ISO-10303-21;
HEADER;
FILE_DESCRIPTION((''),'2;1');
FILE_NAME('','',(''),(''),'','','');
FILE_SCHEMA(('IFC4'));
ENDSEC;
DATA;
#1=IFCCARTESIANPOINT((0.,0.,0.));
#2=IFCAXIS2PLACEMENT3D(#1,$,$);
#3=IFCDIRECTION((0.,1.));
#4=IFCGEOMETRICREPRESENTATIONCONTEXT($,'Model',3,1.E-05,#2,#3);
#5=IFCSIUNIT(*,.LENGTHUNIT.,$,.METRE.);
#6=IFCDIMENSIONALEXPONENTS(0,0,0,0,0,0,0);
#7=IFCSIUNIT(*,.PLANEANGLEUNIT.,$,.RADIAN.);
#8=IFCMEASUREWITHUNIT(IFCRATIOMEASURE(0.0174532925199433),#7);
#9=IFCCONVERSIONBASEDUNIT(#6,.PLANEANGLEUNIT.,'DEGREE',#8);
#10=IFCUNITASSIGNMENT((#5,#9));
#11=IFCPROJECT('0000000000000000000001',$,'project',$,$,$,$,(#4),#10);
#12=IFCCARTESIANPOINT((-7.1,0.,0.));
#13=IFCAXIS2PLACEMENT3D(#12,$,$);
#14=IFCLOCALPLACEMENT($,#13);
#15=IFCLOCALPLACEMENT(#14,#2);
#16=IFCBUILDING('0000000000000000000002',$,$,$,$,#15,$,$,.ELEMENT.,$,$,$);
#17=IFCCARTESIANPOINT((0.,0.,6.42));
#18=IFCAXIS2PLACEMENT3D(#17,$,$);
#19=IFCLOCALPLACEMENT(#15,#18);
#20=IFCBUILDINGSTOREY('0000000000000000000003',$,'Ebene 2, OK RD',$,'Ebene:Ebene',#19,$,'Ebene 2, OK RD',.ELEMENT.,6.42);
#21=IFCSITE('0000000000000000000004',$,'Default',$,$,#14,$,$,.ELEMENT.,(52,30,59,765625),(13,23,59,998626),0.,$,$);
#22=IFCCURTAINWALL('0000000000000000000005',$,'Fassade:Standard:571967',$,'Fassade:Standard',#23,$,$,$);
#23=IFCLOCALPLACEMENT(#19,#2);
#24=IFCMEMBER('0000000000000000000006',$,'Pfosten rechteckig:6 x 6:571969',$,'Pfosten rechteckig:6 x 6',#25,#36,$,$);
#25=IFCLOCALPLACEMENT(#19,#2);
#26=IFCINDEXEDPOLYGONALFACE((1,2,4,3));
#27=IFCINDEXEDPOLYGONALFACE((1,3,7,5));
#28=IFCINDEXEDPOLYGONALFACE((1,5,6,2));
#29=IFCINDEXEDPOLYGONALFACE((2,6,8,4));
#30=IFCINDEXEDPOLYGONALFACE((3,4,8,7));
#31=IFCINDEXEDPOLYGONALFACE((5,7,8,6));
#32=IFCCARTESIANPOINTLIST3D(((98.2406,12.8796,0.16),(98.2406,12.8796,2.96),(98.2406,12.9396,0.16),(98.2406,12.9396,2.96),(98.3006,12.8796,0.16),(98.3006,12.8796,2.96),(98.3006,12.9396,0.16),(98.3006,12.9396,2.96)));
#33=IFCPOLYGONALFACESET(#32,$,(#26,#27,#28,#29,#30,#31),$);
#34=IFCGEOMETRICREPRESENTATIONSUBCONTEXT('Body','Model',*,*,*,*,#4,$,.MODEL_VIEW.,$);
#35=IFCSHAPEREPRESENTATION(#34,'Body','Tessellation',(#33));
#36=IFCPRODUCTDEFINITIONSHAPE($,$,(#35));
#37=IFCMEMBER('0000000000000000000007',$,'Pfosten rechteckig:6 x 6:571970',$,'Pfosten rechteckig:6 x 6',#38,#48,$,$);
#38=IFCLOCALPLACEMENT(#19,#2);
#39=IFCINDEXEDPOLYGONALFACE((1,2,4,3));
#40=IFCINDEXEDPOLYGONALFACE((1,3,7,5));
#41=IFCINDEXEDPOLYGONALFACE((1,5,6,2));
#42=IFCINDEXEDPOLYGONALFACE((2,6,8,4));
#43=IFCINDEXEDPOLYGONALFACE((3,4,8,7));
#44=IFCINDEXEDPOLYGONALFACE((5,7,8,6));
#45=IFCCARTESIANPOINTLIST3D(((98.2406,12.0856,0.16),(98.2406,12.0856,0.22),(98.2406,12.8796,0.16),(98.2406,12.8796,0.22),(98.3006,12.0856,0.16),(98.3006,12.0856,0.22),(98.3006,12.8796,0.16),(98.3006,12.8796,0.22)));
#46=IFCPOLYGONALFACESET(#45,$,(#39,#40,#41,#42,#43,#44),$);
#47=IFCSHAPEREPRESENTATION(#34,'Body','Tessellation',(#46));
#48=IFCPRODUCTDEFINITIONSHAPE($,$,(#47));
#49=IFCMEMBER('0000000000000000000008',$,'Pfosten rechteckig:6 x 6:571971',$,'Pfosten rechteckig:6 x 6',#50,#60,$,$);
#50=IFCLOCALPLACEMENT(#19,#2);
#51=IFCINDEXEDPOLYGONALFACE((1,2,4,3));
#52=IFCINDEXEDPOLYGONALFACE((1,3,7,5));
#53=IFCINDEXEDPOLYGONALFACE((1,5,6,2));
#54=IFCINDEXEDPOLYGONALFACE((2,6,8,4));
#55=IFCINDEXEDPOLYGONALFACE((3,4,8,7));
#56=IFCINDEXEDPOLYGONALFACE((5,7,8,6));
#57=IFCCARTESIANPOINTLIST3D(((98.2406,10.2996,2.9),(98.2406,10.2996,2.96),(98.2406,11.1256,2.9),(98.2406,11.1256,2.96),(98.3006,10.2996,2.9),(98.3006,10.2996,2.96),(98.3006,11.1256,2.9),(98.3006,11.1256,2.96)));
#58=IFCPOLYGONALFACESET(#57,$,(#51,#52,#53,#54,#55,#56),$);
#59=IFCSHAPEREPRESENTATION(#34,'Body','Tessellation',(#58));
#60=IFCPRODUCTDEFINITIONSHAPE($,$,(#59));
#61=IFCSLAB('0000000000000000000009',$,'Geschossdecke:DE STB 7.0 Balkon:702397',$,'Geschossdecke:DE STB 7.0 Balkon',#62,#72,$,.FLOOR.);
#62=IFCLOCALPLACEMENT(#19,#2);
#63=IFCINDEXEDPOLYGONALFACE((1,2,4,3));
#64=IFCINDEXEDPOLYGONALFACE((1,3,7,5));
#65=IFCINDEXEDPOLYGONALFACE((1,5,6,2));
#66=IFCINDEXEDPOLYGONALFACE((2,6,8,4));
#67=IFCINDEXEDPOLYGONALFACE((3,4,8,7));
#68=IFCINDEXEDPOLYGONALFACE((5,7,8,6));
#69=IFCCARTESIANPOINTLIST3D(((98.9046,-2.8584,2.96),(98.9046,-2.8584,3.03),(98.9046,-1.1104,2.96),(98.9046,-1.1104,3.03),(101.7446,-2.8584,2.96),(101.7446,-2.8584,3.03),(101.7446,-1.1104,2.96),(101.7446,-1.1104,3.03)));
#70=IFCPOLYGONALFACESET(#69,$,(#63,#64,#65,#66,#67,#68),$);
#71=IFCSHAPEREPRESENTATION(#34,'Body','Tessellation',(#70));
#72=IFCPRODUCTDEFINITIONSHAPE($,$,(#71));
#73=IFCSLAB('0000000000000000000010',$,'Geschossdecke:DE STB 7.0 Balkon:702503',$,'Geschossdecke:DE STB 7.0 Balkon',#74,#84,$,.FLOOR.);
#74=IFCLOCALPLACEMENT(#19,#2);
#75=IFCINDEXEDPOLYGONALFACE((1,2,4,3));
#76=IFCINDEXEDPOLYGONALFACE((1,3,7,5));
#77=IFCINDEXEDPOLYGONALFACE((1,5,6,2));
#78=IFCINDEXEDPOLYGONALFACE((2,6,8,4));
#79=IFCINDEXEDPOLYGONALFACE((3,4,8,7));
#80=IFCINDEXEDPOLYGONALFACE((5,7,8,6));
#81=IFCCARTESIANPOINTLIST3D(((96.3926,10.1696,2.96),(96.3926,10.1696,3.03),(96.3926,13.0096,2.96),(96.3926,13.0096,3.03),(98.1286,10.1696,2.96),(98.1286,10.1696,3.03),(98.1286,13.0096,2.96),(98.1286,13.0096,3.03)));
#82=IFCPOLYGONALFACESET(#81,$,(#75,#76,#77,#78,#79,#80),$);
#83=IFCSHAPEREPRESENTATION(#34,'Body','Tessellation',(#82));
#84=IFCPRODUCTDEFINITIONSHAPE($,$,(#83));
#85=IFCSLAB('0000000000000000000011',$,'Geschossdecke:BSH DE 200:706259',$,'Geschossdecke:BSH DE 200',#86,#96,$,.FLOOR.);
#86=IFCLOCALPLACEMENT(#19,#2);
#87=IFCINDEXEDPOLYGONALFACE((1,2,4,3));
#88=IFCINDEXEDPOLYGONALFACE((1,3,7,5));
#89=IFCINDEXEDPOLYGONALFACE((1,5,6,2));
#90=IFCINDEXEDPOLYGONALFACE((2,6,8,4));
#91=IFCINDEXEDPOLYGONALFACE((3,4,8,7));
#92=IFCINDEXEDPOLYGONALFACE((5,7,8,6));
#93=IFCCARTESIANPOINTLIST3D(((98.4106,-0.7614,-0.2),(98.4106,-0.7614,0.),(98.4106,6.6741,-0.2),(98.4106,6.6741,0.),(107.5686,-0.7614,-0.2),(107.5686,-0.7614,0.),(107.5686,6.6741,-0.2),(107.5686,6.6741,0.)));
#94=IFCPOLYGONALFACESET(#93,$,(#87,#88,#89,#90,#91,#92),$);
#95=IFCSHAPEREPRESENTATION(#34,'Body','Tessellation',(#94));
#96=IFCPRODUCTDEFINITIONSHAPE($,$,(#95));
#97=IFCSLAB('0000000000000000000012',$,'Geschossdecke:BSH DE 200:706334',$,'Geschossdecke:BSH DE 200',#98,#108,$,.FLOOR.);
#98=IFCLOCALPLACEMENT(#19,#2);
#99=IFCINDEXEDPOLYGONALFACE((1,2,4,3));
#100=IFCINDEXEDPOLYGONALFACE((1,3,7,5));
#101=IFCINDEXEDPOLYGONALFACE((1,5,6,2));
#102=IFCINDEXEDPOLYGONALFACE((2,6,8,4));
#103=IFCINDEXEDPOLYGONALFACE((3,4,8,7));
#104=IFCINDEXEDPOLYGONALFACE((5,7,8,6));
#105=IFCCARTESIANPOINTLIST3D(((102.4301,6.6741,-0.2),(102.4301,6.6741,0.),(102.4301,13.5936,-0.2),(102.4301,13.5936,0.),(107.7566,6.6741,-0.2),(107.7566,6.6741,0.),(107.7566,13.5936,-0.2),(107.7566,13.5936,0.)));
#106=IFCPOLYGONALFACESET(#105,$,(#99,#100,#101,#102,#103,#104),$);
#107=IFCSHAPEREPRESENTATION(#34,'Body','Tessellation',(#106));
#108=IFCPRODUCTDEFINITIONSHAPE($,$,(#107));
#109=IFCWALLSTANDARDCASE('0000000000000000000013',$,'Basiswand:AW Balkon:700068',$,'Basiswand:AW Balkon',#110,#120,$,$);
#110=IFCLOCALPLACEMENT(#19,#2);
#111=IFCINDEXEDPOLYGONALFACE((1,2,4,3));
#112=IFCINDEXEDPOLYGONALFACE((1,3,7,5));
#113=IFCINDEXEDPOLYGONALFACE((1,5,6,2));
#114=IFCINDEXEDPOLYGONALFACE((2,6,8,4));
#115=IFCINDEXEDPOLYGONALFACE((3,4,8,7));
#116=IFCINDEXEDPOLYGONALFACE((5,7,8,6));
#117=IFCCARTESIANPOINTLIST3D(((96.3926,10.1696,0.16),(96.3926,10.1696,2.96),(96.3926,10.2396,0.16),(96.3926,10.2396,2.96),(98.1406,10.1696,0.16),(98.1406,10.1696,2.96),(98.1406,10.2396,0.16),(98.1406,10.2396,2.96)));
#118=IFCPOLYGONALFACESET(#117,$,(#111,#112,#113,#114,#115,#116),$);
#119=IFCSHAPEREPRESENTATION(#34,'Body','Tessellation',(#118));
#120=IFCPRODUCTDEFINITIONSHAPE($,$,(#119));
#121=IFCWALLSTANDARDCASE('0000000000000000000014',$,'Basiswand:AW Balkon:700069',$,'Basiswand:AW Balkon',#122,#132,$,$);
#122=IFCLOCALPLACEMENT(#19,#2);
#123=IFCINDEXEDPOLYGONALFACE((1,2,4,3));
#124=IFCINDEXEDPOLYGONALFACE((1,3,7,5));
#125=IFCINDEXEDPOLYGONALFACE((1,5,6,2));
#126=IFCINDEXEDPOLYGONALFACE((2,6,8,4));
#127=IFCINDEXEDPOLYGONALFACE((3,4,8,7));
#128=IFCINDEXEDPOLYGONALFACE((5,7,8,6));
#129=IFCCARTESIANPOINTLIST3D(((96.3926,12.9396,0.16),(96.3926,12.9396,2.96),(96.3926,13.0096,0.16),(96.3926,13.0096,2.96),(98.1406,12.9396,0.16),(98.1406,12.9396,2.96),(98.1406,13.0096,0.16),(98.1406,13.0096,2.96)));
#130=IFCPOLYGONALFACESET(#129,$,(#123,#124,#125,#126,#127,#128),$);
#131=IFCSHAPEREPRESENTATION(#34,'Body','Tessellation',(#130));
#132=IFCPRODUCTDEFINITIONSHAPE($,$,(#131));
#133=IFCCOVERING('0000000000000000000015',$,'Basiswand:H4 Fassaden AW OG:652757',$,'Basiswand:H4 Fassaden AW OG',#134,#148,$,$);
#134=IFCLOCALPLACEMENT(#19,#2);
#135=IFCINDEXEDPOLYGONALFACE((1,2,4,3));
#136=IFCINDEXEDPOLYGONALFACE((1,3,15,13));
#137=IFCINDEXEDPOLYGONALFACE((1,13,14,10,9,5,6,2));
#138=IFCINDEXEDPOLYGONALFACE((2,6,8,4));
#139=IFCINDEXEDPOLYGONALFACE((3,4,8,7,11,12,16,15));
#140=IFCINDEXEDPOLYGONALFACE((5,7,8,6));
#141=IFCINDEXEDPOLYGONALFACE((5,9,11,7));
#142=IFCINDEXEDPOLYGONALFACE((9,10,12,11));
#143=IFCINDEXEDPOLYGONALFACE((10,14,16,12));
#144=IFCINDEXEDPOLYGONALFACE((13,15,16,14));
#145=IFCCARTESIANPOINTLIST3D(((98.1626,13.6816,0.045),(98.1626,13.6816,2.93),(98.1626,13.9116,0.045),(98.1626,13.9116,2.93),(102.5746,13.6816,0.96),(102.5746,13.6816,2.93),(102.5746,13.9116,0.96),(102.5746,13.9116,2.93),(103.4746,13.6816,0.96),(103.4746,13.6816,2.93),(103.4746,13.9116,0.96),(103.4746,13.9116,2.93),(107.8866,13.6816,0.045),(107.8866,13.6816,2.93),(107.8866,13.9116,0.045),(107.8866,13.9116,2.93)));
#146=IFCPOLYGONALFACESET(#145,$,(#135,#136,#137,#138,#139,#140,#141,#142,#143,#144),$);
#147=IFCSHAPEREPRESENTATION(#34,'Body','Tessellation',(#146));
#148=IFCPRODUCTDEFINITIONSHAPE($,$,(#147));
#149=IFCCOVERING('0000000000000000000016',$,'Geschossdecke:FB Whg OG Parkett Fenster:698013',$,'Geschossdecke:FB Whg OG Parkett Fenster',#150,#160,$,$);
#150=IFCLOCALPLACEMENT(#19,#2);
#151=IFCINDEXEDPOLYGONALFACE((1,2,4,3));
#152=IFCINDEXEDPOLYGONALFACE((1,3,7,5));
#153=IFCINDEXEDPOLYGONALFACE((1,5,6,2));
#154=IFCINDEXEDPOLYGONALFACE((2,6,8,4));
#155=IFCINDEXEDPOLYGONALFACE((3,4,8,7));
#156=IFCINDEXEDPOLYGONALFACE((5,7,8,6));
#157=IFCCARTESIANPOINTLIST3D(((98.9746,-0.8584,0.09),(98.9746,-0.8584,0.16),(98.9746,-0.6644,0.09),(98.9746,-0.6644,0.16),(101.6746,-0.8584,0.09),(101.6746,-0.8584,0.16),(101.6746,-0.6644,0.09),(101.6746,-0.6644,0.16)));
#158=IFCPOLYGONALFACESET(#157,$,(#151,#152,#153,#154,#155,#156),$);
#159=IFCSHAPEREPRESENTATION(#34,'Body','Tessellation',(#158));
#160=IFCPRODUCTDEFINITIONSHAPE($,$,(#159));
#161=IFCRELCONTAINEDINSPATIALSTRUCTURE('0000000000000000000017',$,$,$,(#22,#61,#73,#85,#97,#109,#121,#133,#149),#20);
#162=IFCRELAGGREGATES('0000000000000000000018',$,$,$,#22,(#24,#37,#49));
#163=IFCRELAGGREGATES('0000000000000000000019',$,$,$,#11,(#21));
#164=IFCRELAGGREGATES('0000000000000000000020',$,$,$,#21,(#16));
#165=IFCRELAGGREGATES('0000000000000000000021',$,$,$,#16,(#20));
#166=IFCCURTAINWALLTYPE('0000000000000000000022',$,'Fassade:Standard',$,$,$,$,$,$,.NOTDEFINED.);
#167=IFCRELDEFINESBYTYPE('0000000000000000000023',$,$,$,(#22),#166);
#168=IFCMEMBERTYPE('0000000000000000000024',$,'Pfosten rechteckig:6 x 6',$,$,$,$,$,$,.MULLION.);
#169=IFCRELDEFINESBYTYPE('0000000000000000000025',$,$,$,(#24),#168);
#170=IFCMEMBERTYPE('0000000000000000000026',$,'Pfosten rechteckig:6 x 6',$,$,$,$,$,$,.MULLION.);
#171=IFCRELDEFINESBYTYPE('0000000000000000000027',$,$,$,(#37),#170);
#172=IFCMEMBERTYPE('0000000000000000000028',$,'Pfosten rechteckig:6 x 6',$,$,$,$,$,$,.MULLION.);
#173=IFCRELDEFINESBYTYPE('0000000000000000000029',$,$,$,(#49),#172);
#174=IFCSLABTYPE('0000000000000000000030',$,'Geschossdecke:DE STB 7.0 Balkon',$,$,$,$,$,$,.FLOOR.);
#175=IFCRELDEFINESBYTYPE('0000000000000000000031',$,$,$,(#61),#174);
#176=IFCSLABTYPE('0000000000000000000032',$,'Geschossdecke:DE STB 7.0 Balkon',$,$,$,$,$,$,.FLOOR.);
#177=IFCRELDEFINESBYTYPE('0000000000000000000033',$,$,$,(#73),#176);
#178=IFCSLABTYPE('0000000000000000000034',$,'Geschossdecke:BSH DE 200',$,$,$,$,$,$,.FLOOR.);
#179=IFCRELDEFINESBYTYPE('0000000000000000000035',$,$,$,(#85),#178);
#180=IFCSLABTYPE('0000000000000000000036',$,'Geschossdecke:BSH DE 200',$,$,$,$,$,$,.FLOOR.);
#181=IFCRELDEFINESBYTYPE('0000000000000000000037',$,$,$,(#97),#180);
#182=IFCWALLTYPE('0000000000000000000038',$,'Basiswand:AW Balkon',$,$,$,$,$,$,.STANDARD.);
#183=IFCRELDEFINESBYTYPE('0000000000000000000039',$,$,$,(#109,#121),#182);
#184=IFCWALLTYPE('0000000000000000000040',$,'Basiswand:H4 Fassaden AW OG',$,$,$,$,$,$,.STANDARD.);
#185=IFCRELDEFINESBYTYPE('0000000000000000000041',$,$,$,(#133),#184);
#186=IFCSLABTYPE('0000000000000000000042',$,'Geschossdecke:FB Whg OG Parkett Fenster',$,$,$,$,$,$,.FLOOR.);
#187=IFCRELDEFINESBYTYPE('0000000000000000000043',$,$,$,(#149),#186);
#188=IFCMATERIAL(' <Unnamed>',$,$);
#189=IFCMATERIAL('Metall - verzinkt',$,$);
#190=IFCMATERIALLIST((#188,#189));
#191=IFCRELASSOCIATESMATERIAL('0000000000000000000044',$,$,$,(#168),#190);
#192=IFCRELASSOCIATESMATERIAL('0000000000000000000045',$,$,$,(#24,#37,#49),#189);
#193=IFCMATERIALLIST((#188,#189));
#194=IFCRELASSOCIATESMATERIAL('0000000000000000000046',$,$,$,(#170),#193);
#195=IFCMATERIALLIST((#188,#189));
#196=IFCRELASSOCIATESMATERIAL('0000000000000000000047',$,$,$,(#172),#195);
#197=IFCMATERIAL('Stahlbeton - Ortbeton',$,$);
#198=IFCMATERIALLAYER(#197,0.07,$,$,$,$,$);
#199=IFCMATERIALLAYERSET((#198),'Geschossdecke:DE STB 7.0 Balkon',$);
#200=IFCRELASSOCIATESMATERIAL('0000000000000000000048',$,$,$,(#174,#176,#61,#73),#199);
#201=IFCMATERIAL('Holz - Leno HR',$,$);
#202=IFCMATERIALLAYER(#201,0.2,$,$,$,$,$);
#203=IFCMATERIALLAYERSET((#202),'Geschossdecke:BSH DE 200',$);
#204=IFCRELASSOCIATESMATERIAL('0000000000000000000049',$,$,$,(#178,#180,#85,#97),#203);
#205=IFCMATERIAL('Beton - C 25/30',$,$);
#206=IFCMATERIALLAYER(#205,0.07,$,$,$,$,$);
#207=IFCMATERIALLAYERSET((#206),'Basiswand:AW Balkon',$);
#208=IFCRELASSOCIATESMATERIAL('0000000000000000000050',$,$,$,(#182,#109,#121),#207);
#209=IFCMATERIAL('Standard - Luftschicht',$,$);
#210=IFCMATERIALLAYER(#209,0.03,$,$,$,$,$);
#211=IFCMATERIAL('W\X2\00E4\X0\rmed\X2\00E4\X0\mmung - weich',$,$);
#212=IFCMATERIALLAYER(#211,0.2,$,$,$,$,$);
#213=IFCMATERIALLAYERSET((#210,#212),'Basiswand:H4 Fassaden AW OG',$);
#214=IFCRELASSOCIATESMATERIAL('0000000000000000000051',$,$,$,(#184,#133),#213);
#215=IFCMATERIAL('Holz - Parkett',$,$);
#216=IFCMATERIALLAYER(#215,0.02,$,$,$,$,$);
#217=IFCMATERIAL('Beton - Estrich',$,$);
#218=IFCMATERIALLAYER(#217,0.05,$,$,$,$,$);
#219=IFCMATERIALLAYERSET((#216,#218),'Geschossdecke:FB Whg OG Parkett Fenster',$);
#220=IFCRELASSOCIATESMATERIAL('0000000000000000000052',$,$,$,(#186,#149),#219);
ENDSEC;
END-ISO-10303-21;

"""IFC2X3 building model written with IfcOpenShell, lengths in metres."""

from ifc_helpers import new_model, entity, si_unit, converted_unit, direction, frame, frame_2d, origin, origin_2d_with_axis, place, context, subcontext, project, spatial, rectangle, extrude, source, transform, mapped, material, material_list, layer, layer_set, layer_usage, type_object, type_shapes, element, aggregate, save


model = new_model("IFC2X3")

# Units and contexts
model_context = context("Model", 3, precision=1e-05, world=origin(), true_north=direction((0.0, 1.0)))
body_context = subcontext(model_context, "Body", "Model", "MODEL_VIEW")
ifc_project = project(units=[si_unit("LENGTHUNIT", "METRE"), converted_unit("PLANEANGLEUNIT", "DEGREE", entity("IfcRatioMeasure", 0.0174532925199433), si_unit("PLANEANGLEUNIT", "RADIAN"), dimensions=[0, 0, 0, 0, 0, 0, 0])], contexts=[model_context])

# Site, building, storey
site_placement = place(None, frame((-7.1, 0.0, 0.0)))
site = spatial("IfcSite", under=ifc_project, at=site_placement, Name="Default", CompositionType="ELEMENT", RefLatitude=(52, 30, 59, 765625), RefLongitude=(13, 23, 59, 998626), RefElevation=0.0)
building_placement = place(site_placement, origin())
building = spatial("IfcBuilding", under=site, at=building_placement, CompositionType="ELEMENT")
storey_placement = place(building_placement, frame((0.0, 0.0, 6.42)))
storey = spatial("IfcBuildingStorey", under=building, at=storey_placement, Name="Ebene 2, OK RD", ObjectType="Ebene:Ebene", LongName="Ebene 2, OK RD", CompositionType="ELEMENT", Elevation=6.42)

# Curtain wall, members
curtain_wall_type = type_object("IfcCurtainWallType", Name="Fassade:Standard", PredefinedType="NOTDEFINED")
curtain_wall_placement = place(storey_placement, frame((0.0, 0.0, -6.42)))
curtain_wall = element("IfcCurtainWall", 1, at=curtain_wall_placement, inside=storey, type_object=curtain_wall_type, Name="Fassade:Standard:571967", ObjectType="Fassade:Standard")
ifc_material_1 = material(Name="Metall - verzinkt")
ifc_material_2 = material(Name=" <Unnamed>")
ifc_material_list_1 = material_list([ifc_material_2, ifc_material_1])
member_type_1 = type_object("IfcMemberType", Name="Pfosten rechteckig:6 x 6", PredefinedType="MULLION", material=ifc_material_list_1)
shared_shape_1 = source(origin(), body_context, "Body", "SweptSolid", [
    extrude(rectangle(XDim=0.06, YDim=0.06, at=origin_2d_with_axis()), frame((-0.03, 0.0, -2.8), z_axis=(0.0, 0.0, 1.0), x_axis=(0.0, -1.0, 0.0)), (0.0, 0.0, 1.0), 2.8),
])
type_shapes(member_type_1, [shared_shape_1])
member_1_placement = place(storey_placement, frame((98.2706, 12.9396, 2.96), z_axis=(0.0, 0.0, 1.0), x_axis=(0.0, 1.0, 0.0)))
member_1 = element("IfcMember", 2, at=member_1_placement, type_object=member_type_1, material=ifc_material_1, Name="Pfosten rechteckig:6 x 6:571969", ObjectType="Pfosten rechteckig:6 x 6", context=body_context, shape_type="MappedRepresentation", body=[
    mapped(shared_shape_1, transform((0.0, 0.0, 0.0), scale=1.0)),
])
ifc_material_list_2 = material_list([ifc_material_2, ifc_material_1])
member_type_2 = type_object("IfcMemberType", Name="Pfosten rechteckig:6 x 6", PredefinedType="MULLION", material=ifc_material_list_2)
shared_shape_2 = source(origin(), body_context, "Body", "SweptSolid", [
    extrude(rectangle(XDim=0.06, YDim=0.06, at=origin_2d_with_axis()), frame((-0.03, 0.0, -0.794), z_axis=(0.0, 0.0, 1.0), x_axis=(0.0, -1.0, 0.0)), (0.0, 0.0, 1.0), 0.794),
])
type_shapes(member_type_2, [shared_shape_2])
member_2_placement = place(storey_placement, frame((98.2706, 12.8796, 0.16), z_axis=(0.0, 1.0, 0.0), x_axis=(0.0, 0.0, -1.0)))
member_2 = element("IfcMember", 3, at=member_2_placement, type_object=member_type_2, material=ifc_material_1, Name="Pfosten rechteckig:6 x 6:571970", ObjectType="Pfosten rechteckig:6 x 6", context=body_context, shape_type="MappedRepresentation", body=[
    mapped(shared_shape_2, transform((0.0, 0.0, 0.0), scale=1.0)),
])
ifc_material_list_3 = material_list([ifc_material_2, ifc_material_1])
member_type_3 = type_object("IfcMemberType", Name="Pfosten rechteckig:6 x 6", PredefinedType="MULLION", material=ifc_material_list_3)
shared_shape_3 = source(origin(), body_context, "Body", "SweptSolid", [
    extrude(rectangle(XDim=0.06, YDim=0.06, at=origin_2d_with_axis()), frame((-0.03, 0.0, -0.826), z_axis=(0.0, 0.0, 1.0), x_axis=(0.0, -1.0, 0.0)), (0.0, 0.0, 1.0), 0.826),
])
type_shapes(member_type_3, [shared_shape_3])
member_3_placement = place(storey_placement, frame((98.2706, 10.2996, 2.96), z_axis=(0.0, -1.0, 0.0), x_axis=(0.0, 0.0, 1.0)))
member_3 = element("IfcMember", 4, at=member_3_placement, type_object=member_type_3, material=ifc_material_1, Name="Pfosten rechteckig:6 x 6:571971", ObjectType="Pfosten rechteckig:6 x 6", context=body_context, shape_type="MappedRepresentation", body=[
    mapped(shared_shape_3, transform((0.0, 0.0, 0.0), scale=1.0)),
])
aggregate(curtain_wall, [member_1, member_2, member_3])

# Slabs
ifc_material_3 = material(Name="Stahlbeton - Ortbeton")
ifc_layer_1 = layer(ifc_material_3, 0.07)
ifc_layer_set_1 = layer_set([ifc_layer_1], Name="Geschossdecke:DE STB 7.0 Balkon")
ifc_layer_usage_1 = layer_usage(ifc_layer_set_1, "AXIS3", "POSITIVE", 0.0)
slab_type_1 = type_object("IfcSlabType", Name="Geschossdecke:DE STB 7.0 Balkon", PredefinedType="FLOOR", material=ifc_layer_set_1)
slab_1_placement = place(storey_placement, origin())
element("IfcSlab", 5, at=slab_1_placement, inside=storey, type_object=slab_type_1, material=ifc_layer_usage_1, Name="Geschossdecke:DE STB 7.0 Balkon:702397", ObjectType="Geschossdecke:DE STB 7.0 Balkon", PredefinedType="FLOOR", context=body_context, shape_type="SweptSolid", body=[
    extrude(rectangle(XDim=1.748, YDim=2.84, at=origin_2d_with_axis()), frame((100.3246, -1.9844, 3.03), z_axis=(0.0, 0.0, -1.0), x_axis=(0.0, 1.0, 0.0)), (0.0, 0.0, 1.0), 0.07),
])
ifc_layer_usage_2 = layer_usage(ifc_layer_set_1, "AXIS3", "POSITIVE", 0.0)
slab_type_2 = type_object("IfcSlabType", Name="Geschossdecke:DE STB 7.0 Balkon", PredefinedType="FLOOR", material=ifc_layer_set_1)
slab_2_placement = place(storey_placement, origin())
element("IfcSlab", 6, at=slab_2_placement, inside=storey, type_object=slab_type_2, material=ifc_layer_usage_2, Name="Geschossdecke:DE STB 7.0 Balkon:702503", ObjectType="Geschossdecke:DE STB 7.0 Balkon", PredefinedType="FLOOR", context=body_context, shape_type="SweptSolid", body=[
    extrude(rectangle(XDim=2.84, YDim=1.736, at=frame_2d((0.0, 0.0), x_axis=(1.0, 0.0))), frame((97.2606, 11.5896, 3.03), z_axis=(0.0, 0.0, -1.0), x_axis=(0.0, 1.0, 0.0)), (0.0, 0.0, 1.0), 0.07),
])
ifc_material_4 = material(Name="Holz - Leno HR")
ifc_layer_2 = layer(ifc_material_4, 0.2)
ifc_layer_set_2 = layer_set([ifc_layer_2], Name="Geschossdecke:BSH DE 200")
ifc_layer_usage_3 = layer_usage(ifc_layer_set_2, "AXIS3", "POSITIVE", 0.0)
slab_type_3 = type_object("IfcSlabType", Name="Geschossdecke:BSH DE 200", PredefinedType="FLOOR", material=ifc_layer_set_2)
slab_3_placement = place(storey_placement, origin())
element("IfcSlab", 7, at=slab_3_placement, inside=storey, type_object=slab_type_3, material=ifc_layer_usage_3, Name="Geschossdecke:BSH DE 200:706259", ObjectType="Geschossdecke:BSH DE 200", PredefinedType="FLOOR", context=body_context, shape_type="SweptSolid", body=[
    extrude(rectangle(XDim=7.4355, YDim=9.158, at=frame_2d((0.0, 0.0), x_axis=(1.0, 0.0))), frame((102.9896, 2.9564, 0.0), z_axis=(0.0, 0.0, -1.0), x_axis=(0.0, 1.0, 0.0)), (0.0, 0.0, 1.0), 0.2),
])
ifc_layer_usage_4 = layer_usage(ifc_layer_set_2, "AXIS3", "POSITIVE", 0.0)
slab_type_4 = type_object("IfcSlabType", Name="Geschossdecke:BSH DE 200", PredefinedType="FLOOR", material=ifc_layer_set_2)
slab_4_placement = place(storey_placement, origin())
element("IfcSlab", 8, at=slab_4_placement, inside=storey, type_object=slab_type_4, material=ifc_layer_usage_4, Name="Geschossdecke:BSH DE 200:706334", ObjectType="Geschossdecke:BSH DE 200", PredefinedType="FLOOR", context=body_context, shape_type="SweptSolid", body=[
    extrude(rectangle(XDim=6.9195, YDim=5.3265, at=frame_2d((0.0, 0.0), x_axis=(1.0, 0.0))), frame((105.0934, 10.1339, 0.0), z_axis=(0.0, 0.0, -1.0), x_axis=(0.0, 1.0, 0.0)), (0.0, 0.0, 1.0), 0.2),
])

# Walls
ifc_material_5 = material(Name="Beton - C 25/30")
ifc_layer_3 = layer(ifc_material_5, 0.07)
ifc_layer_set_3 = layer_set([ifc_layer_3], Name="Basiswand:AW Balkon")
ifc_layer_usage_5 = layer_usage(ifc_layer_set_3, "AXIS2", "NEGATIVE", 0.035)
wall_type_1 = type_object("IfcWallType", Name="Basiswand:AW Balkon", PredefinedType="STANDARD", material=ifc_layer_set_3)
wall_1_placement = place(storey_placement, frame((98.1406, 10.2046, 0.16), z_axis=(0.0, 0.0, 1.0), x_axis=(-1.0, 0.0, 0.0)))
element("IfcWallStandardCase", 9, at=wall_1_placement, inside=storey, type_object=wall_type_1, material=ifc_layer_usage_5, Name="Basiswand:AW Balkon:700068", ObjectType="Basiswand:AW Balkon", context=body_context, shape_type="SweptSolid", body=[
    extrude(rectangle(XDim=1.748, YDim=0.07, at=frame_2d((0.874, 0.0), x_axis=(-1.0, 0.0))), origin(), (0.0, 0.0, 1.0), 2.8),
])
ifc_layer_usage_6 = layer_usage(ifc_layer_set_3, "AXIS2", "NEGATIVE", 0.035)
wall_2_placement = place(storey_placement, frame((96.3926, 12.9746, 0.16)))
element("IfcWallStandardCase", 10, at=wall_2_placement, inside=storey, type_object=wall_type_1, material=ifc_layer_usage_6, Name="Basiswand:AW Balkon:700069", ObjectType="Basiswand:AW Balkon", context=body_context, shape_type="SweptSolid", body=[
    extrude(rectangle(XDim=1.748, YDim=0.07, at=frame_2d((0.874, 0.0), x_axis=(-1.0, 0.0))), origin(), (0.0, 0.0, 1.0), 2.8),
])

# Covering, opening
ifc_material_6 = material(Name="Standard - Luftschicht")
ifc_layer_4 = layer(ifc_material_6, 0.03)
ifc_material_7 = material(Name="Wärmedämmung - weich")
ifc_layer_5 = layer(ifc_material_7, 0.2)
ifc_layer_set_4 = layer_set([ifc_layer_4, ifc_layer_5], Name="Basiswand:H4 Fassaden AW OG")
ifc_layer_usage_7 = layer_usage(ifc_layer_set_4, "AXIS2", "NEGATIVE", 0.115)
wall_type_2 = type_object("IfcWallType", Name="Basiswand:H4 Fassaden AW OG", PredefinedType="STANDARD", material=ifc_layer_set_4)
covering_1_placement = place(storey_placement, frame((98.1626, 13.7966, 0.045)))
covering_1 = element("IfcCovering", 11, at=covering_1_placement, inside=storey, type_object=wall_type_2, material=ifc_layer_usage_7, Name="Basiswand:H4 Fassaden AW OG:652757", ObjectType="Basiswand:H4 Fassaden AW OG", context=body_context, shape_type="SweptSolid", body=[
    extrude(rectangle(XDim=9.724, YDim=0.23, at=frame_2d((4.862, 0.0), x_axis=(-1.0, 0.0))), origin(), (0.0, 0.0, 1.0), 2.885),
])
opening_placement = place(covering_1_placement, frame((5.312, 0.115, 0.915)))
element("IfcOpeningElement", 12, at=opening_placement, cuts=covering_1, ObjectType="Opening", context=body_context, shape_type="SweptSolid", body=[
    extrude(rectangle(XDim=1.97, YDim=0.9, at=frame_2d((0.985, 0.45), x_axis=(1.0, 0.0))), frame((0.0, 0.0, 0.0), z_axis=(0.0, -1.0, 0.0), x_axis=(0.0, 0.0, 1.0)), (0.0, 0.0, 1.0), 0.23),
])

# Covering
ifc_material_8 = material(Name="Holz - Parkett")
ifc_layer_6 = layer(ifc_material_8, 0.02)
ifc_material_9 = material(Name="Beton - Estrich")
ifc_layer_7 = layer(ifc_material_9, 0.05)
ifc_layer_set_5 = layer_set([ifc_layer_6, ifc_layer_7], Name="Geschossdecke:FB Whg OG Parkett Fenster")
ifc_layer_usage_8 = layer_usage(ifc_layer_set_5, "AXIS3", "POSITIVE", 0.0)
slab_type_5 = type_object("IfcSlabType", Name="Geschossdecke:FB Whg OG Parkett Fenster", PredefinedType="FLOOR", material=ifc_layer_set_5)
covering_2_placement = place(storey_placement, origin())
element("IfcCovering", 13, at=covering_2_placement, inside=storey, type_object=slab_type_5, material=ifc_layer_usage_8, Name="Geschossdecke:FB Whg OG Parkett Fenster:698013", ObjectType="Geschossdecke:FB Whg OG Parkett Fenster", context=body_context, shape_type="SweptSolid", body=[
    extrude(rectangle(XDim=0.194, YDim=2.7, at=origin_2d_with_axis()), frame((100.3246, -0.7614, 0.16), z_axis=(0.0, 0.0, -1.0), x_axis=(0.0, 1.0, 0.0)), (0.0, 0.0, 1.0), 0.07),
])

save(model, "model.ifc")
